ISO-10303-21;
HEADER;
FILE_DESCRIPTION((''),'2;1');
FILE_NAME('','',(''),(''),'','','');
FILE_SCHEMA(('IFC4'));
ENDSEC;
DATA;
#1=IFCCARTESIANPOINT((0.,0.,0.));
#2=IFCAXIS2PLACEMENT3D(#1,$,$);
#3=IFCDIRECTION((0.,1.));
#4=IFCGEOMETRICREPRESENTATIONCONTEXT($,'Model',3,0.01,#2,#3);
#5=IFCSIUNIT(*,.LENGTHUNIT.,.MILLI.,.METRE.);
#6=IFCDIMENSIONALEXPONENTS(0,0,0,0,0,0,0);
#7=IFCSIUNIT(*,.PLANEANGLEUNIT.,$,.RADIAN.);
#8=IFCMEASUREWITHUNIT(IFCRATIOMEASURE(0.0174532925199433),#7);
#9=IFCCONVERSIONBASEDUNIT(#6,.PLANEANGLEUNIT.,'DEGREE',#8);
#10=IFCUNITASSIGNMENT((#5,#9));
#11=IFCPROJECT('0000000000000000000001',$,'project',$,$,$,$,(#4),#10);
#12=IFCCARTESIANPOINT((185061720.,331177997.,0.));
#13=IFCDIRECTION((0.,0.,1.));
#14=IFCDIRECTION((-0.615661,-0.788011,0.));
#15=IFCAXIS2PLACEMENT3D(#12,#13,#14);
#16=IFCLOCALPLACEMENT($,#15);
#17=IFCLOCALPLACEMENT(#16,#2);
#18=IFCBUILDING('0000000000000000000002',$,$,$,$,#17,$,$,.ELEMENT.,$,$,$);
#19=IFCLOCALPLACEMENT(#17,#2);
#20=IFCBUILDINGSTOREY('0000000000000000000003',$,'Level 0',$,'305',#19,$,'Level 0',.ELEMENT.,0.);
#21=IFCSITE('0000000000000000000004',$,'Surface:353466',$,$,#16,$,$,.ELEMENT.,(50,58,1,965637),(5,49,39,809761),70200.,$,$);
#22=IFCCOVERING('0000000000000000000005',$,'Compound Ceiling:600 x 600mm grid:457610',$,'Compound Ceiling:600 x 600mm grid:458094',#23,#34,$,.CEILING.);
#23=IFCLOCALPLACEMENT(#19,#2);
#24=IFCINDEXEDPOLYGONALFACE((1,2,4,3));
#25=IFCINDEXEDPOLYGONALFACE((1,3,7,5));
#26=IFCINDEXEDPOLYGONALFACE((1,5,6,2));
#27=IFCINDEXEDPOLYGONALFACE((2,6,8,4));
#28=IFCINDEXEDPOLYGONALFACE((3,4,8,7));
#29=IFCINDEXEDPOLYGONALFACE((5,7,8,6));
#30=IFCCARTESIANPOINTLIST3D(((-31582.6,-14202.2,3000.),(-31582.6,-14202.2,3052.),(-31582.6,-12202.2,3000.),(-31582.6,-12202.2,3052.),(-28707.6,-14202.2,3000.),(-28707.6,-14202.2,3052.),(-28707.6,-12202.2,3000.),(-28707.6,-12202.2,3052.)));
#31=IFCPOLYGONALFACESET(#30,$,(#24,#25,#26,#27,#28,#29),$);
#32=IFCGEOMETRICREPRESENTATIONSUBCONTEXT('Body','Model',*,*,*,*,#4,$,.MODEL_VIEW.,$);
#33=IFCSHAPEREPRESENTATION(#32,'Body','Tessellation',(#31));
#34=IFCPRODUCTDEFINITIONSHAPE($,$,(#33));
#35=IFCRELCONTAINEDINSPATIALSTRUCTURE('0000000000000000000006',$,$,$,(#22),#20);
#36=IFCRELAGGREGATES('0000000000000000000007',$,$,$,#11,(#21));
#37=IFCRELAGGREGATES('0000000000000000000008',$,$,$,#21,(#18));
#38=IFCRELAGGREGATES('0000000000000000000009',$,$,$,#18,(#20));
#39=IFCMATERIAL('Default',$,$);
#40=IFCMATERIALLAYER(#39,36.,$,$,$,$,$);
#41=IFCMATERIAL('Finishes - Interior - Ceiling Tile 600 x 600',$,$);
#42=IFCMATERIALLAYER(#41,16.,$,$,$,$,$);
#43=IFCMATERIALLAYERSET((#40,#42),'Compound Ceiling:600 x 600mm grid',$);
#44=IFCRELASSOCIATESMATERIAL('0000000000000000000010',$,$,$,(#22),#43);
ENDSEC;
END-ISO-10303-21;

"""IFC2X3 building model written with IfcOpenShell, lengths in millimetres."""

from ifc_helpers import new_model, entity, si_unit, converted_unit, direction, frame, frame_2d, origin, place, context, subcontext, project, spatial, rectangle, extrude, material, layer, layer_set, layer_usage, element, save


model = new_model("IFC2X3")

# Units and contexts
model_context = context("Model", 3, precision=0.01, world=origin(), true_north=direction((0.0, 1.0)))
body_context = subcontext(model_context, "Body", "Model", "MODEL_VIEW")
ifc_project = project(units=[si_unit("LENGTHUNIT", "METRE", prefix="MILLI"), converted_unit("PLANEANGLEUNIT", "DEGREE", entity("IfcRatioMeasure", 0.0174532925199433), si_unit("PLANEANGLEUNIT", "RADIAN"), dimensions=[0, 0, 0, 0, 0, 0, 0])], contexts=[model_context])

# Site, building, storey
site_placement = place(None, frame((185061720.0, 331177997.0, 0.0), z_axis=(0.0, 0.0, 1.0), x_axis=(-0.615661, -0.788011, 0.0)))
site = spatial("IfcSite", under=ifc_project, at=site_placement, Name="Surface:353466", CompositionType="ELEMENT", RefLatitude=(50, 58, 1, 965637), RefLongitude=(5, 49, 39, 809761), RefElevation=70200.0)
building_placement = place(site_placement, origin())
building = spatial("IfcBuilding", under=site, at=building_placement, CompositionType="ELEMENT")
storey_placement = place(building_placement, origin())
storey = spatial("IfcBuildingStorey", under=building, at=storey_placement, Name="Level 0", ObjectType="305", LongName="Level 0", CompositionType="ELEMENT", Elevation=0.0)

# Covering
ifc_material_1 = material(Name="Default")
ifc_layer_1 = layer(ifc_material_1, 36.0)
ifc_material_2 = material(Name="Finishes - Interior - Ceiling Tile 600 x 600")
ifc_layer_2 = layer(ifc_material_2, 16.0)
ifc_layer_set_1 = layer_set([ifc_layer_1, ifc_layer_2], Name="Compound Ceiling:600 x 600mm grid")
ifc_layer_usage_1 = layer_usage(ifc_layer_set_1, "AXIS3", "POSITIVE", 0.0)
covering_1_placement = place(storey_placement, frame((-31582.6, -14202.2, 3000.0)))
element("IfcCovering", 1, at=covering_1_placement, inside=storey, material=ifc_layer_usage_1, Name="Compound Ceiling:600 x 600mm grid:457610", ObjectType="Compound Ceiling:600 x 600mm grid:458094", PredefinedType="CEILING", context=body_context, shape_type="SweptSolid", body=[
    extrude(rectangle(XDim=2875.0, YDim=2000.0, at=frame_2d((0.0, 0.0), x_axis=(1.0, 0.0))), frame((1437.5, 1000.0, 0.0)), (0.0, 0.0, 1.0), 52.0),
])

save(model, "model.ifc")
